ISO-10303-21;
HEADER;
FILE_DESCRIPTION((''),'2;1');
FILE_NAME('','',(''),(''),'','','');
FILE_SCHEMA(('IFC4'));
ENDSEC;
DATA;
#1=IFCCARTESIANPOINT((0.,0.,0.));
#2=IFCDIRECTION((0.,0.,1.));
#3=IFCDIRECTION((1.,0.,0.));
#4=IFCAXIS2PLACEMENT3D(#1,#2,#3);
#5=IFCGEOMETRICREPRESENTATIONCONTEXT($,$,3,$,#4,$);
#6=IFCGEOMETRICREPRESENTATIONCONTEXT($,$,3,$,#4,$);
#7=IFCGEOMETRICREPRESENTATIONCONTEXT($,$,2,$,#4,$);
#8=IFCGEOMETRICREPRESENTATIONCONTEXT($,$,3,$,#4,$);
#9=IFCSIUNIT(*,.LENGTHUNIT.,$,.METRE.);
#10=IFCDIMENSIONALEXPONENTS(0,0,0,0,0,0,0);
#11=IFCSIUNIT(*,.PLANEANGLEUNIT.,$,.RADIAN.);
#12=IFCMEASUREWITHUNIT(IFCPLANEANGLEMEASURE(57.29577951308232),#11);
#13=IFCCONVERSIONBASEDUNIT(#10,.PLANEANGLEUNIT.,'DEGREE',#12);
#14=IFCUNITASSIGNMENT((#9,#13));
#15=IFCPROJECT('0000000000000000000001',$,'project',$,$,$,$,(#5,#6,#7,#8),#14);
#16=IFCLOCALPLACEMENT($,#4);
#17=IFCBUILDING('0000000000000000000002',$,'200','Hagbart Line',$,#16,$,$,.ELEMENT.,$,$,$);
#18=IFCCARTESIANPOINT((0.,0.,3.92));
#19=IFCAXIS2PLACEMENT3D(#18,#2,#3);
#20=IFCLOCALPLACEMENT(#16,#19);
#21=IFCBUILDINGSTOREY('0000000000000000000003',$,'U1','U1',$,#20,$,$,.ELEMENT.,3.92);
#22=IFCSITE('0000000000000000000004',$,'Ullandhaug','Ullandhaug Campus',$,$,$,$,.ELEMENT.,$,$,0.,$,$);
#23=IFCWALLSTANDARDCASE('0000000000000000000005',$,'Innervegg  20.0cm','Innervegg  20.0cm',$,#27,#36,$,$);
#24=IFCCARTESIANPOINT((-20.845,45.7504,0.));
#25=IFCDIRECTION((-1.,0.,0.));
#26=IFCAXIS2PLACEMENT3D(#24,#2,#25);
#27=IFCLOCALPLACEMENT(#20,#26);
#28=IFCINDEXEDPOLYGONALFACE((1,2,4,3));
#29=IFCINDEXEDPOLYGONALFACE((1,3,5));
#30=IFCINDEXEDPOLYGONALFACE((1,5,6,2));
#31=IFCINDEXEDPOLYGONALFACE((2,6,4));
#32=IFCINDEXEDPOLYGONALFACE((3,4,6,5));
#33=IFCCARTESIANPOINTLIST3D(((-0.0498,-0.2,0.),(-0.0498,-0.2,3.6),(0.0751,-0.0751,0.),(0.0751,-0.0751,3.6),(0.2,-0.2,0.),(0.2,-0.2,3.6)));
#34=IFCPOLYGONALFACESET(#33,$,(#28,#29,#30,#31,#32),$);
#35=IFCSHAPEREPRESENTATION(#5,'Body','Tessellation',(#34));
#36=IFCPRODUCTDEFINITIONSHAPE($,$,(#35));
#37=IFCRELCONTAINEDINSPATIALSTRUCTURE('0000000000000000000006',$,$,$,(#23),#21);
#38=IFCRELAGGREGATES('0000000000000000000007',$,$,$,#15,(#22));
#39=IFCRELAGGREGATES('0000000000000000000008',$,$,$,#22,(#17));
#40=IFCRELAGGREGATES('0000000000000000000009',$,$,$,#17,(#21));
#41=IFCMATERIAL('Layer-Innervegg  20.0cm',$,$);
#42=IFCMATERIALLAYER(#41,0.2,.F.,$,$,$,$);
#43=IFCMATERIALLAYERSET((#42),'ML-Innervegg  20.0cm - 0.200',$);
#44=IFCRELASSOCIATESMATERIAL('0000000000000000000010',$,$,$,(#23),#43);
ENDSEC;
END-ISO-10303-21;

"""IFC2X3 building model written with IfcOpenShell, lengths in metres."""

from ifc_helpers import new_model, entity, si_unit, converted_unit, frame, origin_with_axes, place, context, project, spatial, polyline, outline, extrude, material, layer, layer_set, layer_usage, element, save


model = new_model("IFC2X3")

# Units and contexts
context_of_model_1 = context(None, 3, world=origin_with_axes())
context_of_model_2 = context(None, 3, world=origin_with_axes())
context_of_model_3 = context(None, 2, world=origin_with_axes())
context_of_model_4 = context(None, 3, world=origin_with_axes())
ifc_project = project(units=[si_unit("LENGTHUNIT", "METRE"), converted_unit("PLANEANGLEUNIT", "DEGREE", entity("IfcPlaneAngleMeasure", 57.29577951308232), si_unit("PLANEANGLEUNIT", "RADIAN"), dimensions=[0, 0, 0, 0, 0, 0, 0])], contexts=[context_of_model_1, context_of_model_2, context_of_model_3, context_of_model_4])

# Site, building, storey
site = spatial("IfcSite", under=ifc_project, Name="Ullandhaug", Description="Ullandhaug Campus", CompositionType="ELEMENT", RefElevation=0.0)
building_placement = place(None, origin_with_axes())
building = spatial("IfcBuilding", under=site, at=building_placement, Name="200", Description="Hagbart Line", CompositionType="ELEMENT")
storey_placement = place(building_placement, frame((0.0, 0.0, 3.92), z_axis=(0.0, 0.0, 1.0), x_axis=(1.0, 0.0, 0.0)))
storey = spatial("IfcBuildingStorey", under=building, at=storey_placement, Name="U1", Description="U1", CompositionType="ELEMENT", Elevation=3.92)

# Shared definitions
ifc_material_1 = material(Name="Layer-Innervegg  20.0cm")
ifc_layer_1 = layer(ifc_material_1, 0.2, ventilated=False)
ifc_layer_set_1 = layer_set([ifc_layer_1], Name="ML-Innervegg  20.0cm - 0.200")
ifc_layer_usage_1 = layer_usage(ifc_layer_set_1, "AXIS2", "POSITIVE", 0.0)

# Wall
wall_1_placement = place(storey_placement, frame((-20.845, 45.7504, 0.0), z_axis=(0.0, 0.0, 1.0), x_axis=(-1.0, 0.0, 0.0)))
element("IfcWallStandardCase", 1, at=wall_1_placement, inside=storey, material=ifc_layer_usage_1, Name="Innervegg  20.0cm", Description="Innervegg  20.0cm", context=context_of_model_1, shape_type="SweptSolid", body=[
    extrude(outline(polyline([(0.0, 0.0), (0.1501, 0.0), (-0.0498, 0.2), (0.2, 0.2), (0.0, 0.0)])), frame((0.0, 0.0, 0.0), z_axis=(0.0, 0.0, -1.0), x_axis=(1.0, 0.0, 0.0)), (0.0, 0.0, -1.0), 3.6),
])

save(model, "model.ifc")
